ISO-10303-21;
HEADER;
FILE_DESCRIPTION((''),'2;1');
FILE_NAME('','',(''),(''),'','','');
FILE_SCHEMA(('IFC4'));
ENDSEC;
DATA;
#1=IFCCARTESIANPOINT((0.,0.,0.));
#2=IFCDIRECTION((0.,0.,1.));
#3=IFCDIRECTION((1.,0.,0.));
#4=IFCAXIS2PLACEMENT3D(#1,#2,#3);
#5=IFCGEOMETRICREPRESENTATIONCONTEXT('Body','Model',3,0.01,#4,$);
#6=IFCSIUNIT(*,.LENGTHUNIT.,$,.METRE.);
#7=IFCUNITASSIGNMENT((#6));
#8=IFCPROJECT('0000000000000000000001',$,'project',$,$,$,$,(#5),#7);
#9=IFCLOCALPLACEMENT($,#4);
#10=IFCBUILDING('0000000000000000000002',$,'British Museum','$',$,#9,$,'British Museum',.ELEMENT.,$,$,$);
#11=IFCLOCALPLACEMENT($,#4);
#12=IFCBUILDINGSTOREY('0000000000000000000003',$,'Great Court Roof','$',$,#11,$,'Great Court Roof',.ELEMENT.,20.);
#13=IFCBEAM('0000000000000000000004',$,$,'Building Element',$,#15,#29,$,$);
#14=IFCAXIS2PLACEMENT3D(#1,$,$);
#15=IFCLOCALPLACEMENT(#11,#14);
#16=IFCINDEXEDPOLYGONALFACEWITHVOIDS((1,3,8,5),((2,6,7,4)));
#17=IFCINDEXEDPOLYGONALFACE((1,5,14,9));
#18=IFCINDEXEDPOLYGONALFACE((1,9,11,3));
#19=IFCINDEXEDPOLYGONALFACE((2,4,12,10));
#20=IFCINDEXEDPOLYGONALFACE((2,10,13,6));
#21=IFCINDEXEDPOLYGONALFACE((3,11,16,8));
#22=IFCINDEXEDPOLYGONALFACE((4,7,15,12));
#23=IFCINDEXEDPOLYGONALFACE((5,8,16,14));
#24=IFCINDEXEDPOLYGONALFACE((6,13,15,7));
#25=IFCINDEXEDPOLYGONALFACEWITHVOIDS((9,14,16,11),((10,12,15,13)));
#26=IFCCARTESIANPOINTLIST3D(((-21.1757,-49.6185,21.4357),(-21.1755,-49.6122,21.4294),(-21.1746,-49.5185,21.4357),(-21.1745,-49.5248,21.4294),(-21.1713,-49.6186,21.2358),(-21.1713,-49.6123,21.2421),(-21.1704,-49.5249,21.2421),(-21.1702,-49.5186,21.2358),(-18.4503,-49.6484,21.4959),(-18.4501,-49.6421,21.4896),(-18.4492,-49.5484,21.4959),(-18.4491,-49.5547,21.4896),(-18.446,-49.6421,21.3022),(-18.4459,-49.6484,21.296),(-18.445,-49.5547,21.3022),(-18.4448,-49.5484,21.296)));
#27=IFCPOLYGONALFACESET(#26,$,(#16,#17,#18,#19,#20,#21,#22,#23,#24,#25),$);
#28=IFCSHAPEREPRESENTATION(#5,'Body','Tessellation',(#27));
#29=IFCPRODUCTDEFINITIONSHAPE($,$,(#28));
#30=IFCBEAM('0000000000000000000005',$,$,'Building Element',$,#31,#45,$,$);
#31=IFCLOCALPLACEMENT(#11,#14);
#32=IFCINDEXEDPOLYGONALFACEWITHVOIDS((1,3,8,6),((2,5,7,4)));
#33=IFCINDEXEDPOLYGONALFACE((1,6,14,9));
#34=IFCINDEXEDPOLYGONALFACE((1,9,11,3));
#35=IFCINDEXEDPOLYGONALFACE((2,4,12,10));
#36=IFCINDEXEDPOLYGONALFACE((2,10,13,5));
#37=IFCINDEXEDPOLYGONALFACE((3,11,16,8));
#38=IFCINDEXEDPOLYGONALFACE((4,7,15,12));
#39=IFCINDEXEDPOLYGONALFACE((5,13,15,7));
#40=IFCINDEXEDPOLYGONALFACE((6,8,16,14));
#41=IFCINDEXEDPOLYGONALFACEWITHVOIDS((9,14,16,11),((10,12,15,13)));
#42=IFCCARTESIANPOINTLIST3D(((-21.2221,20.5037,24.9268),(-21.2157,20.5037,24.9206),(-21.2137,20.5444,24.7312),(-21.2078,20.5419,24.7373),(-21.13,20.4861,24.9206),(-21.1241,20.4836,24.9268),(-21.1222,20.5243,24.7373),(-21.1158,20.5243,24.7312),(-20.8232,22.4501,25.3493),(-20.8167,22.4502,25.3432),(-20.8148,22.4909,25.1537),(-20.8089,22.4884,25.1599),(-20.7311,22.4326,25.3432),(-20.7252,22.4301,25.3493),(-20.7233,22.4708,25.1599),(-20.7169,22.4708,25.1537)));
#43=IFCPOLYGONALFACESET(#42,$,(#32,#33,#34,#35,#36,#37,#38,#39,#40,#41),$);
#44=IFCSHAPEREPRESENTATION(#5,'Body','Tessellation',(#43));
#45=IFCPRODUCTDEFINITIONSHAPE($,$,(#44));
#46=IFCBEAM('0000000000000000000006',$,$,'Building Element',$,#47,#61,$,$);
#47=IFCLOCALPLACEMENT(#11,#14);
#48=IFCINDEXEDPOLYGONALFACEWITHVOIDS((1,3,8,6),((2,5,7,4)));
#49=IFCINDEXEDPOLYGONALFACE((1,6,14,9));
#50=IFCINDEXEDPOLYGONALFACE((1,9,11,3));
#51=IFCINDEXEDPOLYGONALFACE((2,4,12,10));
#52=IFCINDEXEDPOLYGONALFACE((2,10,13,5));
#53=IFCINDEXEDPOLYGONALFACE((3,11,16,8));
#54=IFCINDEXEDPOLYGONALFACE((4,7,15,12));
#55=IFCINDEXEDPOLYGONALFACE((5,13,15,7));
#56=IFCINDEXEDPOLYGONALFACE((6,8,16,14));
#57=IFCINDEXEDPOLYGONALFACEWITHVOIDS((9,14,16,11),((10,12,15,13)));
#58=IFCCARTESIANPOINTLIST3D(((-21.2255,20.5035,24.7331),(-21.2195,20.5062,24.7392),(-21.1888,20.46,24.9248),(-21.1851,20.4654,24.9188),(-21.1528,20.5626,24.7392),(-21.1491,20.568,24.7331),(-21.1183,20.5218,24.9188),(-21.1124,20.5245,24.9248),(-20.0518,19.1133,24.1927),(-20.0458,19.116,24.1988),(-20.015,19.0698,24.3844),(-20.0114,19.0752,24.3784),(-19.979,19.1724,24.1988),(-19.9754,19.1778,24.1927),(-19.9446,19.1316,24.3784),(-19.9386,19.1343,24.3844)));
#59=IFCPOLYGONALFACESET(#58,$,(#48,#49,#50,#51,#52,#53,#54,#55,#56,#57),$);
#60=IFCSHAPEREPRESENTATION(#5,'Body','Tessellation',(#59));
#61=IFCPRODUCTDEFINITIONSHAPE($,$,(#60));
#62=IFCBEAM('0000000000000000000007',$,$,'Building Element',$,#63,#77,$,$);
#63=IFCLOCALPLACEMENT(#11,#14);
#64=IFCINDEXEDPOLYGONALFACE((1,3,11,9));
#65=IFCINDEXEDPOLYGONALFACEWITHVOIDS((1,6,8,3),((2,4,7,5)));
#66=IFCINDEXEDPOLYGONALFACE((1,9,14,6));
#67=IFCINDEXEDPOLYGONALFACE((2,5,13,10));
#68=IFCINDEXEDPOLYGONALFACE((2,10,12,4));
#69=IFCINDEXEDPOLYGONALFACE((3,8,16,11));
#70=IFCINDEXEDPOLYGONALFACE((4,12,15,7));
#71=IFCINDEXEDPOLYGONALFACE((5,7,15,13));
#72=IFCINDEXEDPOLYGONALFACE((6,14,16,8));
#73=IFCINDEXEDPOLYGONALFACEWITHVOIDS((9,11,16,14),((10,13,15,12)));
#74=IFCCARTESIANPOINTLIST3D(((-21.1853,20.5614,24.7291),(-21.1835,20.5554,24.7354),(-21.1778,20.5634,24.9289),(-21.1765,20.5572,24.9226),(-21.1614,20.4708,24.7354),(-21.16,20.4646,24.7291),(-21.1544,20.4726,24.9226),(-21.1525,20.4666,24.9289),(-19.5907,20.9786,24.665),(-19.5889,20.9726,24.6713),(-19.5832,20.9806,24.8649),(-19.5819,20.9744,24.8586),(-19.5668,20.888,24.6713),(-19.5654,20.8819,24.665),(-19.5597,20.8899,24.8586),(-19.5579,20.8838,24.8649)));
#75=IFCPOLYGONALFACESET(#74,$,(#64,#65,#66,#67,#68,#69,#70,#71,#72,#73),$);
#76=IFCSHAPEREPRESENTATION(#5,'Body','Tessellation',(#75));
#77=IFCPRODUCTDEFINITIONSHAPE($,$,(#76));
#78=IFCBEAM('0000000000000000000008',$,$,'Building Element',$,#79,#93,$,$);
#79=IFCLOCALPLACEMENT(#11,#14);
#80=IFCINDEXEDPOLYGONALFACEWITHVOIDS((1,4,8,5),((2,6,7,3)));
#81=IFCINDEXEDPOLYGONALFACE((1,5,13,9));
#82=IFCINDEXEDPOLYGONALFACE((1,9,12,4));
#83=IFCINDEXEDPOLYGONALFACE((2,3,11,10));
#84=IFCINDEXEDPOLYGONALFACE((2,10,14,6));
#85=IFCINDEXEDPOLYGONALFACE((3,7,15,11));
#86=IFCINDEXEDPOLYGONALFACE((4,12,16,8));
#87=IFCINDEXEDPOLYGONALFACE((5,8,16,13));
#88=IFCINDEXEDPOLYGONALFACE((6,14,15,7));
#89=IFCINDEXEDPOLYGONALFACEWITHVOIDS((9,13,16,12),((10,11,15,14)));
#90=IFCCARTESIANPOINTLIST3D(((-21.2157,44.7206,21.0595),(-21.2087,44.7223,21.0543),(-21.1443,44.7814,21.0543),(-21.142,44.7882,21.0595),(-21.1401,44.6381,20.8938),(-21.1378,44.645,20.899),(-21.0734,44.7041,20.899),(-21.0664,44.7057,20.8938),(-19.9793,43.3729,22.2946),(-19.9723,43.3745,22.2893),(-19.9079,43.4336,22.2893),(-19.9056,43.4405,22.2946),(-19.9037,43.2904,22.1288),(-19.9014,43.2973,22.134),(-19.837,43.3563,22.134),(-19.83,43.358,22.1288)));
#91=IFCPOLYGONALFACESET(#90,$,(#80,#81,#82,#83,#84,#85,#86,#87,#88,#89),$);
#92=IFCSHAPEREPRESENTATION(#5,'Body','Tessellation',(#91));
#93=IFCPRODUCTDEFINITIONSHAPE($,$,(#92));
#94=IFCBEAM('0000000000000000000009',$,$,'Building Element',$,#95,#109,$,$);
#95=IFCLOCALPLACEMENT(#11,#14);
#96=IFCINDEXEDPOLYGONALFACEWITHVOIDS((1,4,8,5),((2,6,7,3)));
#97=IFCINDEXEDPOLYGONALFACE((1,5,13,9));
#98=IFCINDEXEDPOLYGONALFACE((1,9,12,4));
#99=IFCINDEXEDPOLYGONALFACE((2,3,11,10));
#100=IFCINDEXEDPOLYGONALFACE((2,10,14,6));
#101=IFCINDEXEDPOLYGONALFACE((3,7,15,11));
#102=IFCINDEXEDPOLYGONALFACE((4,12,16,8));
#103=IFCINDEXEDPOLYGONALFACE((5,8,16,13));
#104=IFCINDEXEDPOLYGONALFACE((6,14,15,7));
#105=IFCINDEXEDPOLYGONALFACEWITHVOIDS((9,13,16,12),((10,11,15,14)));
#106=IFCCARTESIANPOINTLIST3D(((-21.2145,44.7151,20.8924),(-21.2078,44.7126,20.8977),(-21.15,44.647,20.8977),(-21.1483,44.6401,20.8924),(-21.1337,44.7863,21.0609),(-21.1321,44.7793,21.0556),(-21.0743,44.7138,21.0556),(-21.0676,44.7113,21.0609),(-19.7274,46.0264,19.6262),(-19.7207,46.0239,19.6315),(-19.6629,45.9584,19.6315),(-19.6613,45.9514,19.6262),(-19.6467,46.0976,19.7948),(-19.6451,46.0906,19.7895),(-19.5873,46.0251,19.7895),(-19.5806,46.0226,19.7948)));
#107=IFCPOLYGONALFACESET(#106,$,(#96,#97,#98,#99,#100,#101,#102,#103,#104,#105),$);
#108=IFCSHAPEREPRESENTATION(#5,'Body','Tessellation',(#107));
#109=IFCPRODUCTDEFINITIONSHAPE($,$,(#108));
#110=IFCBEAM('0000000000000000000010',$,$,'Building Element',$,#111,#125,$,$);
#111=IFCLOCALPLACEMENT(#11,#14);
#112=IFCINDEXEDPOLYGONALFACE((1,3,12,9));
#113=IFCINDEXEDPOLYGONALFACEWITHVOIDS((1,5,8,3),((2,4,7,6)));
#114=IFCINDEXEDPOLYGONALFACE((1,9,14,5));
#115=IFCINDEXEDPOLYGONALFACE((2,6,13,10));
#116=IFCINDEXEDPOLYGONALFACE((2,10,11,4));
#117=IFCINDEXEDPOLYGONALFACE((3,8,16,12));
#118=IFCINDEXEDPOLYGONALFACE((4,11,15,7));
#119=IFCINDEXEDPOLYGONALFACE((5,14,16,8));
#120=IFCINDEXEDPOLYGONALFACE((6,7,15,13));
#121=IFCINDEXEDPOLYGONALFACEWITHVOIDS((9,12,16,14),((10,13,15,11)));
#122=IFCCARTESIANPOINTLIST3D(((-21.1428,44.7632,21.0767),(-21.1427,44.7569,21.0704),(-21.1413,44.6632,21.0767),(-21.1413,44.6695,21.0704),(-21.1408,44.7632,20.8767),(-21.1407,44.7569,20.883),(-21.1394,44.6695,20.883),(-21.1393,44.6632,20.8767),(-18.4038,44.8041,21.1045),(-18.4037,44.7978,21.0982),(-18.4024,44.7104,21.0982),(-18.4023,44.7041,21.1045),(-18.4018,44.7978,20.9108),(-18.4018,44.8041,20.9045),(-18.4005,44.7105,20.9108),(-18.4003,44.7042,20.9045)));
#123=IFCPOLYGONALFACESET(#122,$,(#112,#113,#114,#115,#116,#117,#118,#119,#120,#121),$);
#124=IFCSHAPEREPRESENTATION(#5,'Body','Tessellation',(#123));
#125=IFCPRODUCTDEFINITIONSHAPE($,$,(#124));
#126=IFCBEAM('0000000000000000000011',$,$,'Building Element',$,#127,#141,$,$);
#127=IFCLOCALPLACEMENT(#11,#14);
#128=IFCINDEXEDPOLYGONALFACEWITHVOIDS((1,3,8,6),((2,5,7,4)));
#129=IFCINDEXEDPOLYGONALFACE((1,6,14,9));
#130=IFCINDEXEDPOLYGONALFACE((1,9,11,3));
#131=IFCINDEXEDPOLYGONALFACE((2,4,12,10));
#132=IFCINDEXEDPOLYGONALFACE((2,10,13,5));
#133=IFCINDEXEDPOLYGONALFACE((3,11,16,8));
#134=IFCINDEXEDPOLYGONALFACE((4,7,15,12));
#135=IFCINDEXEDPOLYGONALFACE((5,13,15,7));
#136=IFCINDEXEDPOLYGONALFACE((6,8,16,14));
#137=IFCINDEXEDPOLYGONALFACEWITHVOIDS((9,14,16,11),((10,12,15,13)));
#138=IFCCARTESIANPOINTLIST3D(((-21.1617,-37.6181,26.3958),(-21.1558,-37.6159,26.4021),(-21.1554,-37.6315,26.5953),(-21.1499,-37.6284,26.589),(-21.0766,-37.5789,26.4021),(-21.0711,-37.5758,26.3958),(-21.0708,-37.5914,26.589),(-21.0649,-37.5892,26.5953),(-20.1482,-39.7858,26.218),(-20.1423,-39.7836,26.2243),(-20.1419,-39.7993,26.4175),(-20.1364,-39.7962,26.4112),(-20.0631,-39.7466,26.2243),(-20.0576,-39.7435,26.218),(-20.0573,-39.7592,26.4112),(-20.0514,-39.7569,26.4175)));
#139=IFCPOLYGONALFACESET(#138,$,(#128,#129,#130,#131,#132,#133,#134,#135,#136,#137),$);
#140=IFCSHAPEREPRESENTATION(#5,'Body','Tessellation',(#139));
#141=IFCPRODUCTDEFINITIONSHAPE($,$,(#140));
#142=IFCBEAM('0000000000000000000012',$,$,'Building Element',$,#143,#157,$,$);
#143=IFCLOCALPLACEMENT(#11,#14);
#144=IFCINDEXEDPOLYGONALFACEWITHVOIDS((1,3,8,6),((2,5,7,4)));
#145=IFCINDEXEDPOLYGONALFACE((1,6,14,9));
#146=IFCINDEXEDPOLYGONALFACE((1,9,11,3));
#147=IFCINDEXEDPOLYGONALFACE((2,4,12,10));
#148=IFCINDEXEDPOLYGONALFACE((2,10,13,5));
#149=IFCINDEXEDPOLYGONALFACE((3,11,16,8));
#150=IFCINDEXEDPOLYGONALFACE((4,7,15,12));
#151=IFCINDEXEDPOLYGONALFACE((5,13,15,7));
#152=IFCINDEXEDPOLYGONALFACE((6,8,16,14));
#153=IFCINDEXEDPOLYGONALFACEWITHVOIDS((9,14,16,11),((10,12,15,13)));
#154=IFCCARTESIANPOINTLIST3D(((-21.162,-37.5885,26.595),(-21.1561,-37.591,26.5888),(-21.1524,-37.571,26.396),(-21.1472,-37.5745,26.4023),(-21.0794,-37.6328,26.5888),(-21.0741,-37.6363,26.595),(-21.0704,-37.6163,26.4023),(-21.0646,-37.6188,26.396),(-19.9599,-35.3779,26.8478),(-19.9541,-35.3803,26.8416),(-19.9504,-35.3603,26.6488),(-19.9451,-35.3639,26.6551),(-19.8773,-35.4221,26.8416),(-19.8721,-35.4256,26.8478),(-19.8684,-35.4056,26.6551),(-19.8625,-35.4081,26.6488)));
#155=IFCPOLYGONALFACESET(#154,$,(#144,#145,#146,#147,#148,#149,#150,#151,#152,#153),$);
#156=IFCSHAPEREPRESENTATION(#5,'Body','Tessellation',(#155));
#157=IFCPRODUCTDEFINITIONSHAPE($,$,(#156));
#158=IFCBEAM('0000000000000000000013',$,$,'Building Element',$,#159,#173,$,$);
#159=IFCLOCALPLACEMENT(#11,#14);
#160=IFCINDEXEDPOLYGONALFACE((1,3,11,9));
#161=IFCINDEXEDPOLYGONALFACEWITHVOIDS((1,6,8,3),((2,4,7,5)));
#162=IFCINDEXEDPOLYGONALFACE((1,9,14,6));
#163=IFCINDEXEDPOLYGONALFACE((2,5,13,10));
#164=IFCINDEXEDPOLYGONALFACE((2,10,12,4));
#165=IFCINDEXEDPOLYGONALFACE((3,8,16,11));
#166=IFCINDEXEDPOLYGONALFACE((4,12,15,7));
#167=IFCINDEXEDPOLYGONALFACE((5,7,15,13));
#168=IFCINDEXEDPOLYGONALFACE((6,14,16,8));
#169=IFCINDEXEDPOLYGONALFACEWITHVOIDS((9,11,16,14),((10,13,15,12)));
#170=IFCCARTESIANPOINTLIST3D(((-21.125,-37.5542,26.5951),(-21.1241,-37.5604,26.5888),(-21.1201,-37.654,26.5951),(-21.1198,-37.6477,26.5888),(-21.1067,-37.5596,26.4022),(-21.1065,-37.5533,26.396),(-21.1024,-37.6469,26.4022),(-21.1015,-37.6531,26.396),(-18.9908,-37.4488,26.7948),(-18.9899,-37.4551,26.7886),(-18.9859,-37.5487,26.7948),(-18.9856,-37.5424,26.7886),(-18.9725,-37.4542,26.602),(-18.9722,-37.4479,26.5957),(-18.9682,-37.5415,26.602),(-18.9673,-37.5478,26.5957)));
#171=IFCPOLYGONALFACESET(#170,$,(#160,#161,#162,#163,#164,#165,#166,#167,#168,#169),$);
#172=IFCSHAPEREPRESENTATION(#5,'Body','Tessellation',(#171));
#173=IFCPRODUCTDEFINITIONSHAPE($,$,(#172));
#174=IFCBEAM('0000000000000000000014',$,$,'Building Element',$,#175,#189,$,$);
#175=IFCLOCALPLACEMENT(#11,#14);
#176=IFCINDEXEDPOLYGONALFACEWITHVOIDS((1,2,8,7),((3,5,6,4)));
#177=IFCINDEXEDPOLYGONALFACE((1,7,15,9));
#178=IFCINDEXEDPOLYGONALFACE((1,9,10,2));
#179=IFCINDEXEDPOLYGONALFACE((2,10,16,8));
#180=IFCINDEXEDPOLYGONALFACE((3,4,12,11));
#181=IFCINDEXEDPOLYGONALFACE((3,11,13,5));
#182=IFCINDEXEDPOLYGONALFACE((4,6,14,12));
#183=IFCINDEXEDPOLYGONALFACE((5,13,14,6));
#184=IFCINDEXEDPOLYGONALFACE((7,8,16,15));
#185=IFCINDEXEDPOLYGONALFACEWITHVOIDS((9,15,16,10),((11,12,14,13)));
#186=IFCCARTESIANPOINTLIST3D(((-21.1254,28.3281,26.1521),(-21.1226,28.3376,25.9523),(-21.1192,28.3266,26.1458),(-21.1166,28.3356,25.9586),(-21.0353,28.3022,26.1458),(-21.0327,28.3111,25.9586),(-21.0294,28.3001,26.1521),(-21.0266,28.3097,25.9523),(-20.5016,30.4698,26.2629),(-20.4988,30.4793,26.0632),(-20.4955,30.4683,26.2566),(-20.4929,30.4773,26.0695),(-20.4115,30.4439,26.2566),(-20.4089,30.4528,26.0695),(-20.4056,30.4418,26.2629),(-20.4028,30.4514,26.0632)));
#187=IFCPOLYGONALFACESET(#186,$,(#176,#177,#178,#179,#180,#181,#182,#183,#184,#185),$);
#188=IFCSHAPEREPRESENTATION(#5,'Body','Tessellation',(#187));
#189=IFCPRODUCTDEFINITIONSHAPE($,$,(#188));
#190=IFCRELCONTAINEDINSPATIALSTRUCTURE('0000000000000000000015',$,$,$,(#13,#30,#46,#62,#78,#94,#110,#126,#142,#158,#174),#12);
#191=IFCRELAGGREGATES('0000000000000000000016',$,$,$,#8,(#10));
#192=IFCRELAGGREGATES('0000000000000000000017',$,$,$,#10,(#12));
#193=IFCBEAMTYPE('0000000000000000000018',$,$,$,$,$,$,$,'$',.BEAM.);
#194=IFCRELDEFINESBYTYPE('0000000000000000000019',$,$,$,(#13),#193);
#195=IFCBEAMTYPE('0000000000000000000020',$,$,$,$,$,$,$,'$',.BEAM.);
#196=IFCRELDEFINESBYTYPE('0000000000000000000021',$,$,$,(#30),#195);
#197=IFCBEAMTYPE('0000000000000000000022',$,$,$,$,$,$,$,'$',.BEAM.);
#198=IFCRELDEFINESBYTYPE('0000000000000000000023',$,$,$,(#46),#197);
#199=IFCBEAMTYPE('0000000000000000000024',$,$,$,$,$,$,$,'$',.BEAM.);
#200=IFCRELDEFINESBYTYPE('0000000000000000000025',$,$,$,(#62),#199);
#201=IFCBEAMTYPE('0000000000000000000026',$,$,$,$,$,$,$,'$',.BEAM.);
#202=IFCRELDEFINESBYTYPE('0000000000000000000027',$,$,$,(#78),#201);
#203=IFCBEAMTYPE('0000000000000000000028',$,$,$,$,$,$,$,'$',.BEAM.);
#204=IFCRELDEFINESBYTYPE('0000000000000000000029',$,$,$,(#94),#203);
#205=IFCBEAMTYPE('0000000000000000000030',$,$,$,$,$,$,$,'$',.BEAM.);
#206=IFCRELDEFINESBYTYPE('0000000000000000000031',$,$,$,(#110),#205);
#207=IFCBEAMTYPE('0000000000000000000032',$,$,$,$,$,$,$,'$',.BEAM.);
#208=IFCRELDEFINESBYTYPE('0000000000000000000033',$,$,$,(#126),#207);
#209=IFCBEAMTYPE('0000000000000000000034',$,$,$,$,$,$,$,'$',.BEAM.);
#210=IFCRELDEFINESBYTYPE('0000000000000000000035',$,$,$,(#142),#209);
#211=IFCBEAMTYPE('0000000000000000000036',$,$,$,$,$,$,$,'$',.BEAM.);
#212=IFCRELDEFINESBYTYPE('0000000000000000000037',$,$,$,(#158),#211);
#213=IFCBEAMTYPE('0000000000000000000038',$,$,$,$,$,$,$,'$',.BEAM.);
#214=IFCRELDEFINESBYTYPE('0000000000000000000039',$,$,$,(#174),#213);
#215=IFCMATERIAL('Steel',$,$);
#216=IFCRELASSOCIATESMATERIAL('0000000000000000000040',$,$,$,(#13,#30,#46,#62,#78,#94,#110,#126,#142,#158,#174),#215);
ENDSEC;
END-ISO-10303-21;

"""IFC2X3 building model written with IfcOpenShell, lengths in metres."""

from ifc_helpers import new_model, si_unit, frame, origin_with_axes, origin_2d, place, context, project, spatial, hollow_rectangle, extrude, material, type_object, element, save


model = new_model("IFC2X3")

# Units and contexts
model_context = context("Model", 3, precision=0.01, world=origin_with_axes(), identifier="Body")
ifc_project = project(units=[si_unit("LENGTHUNIT", "METRE")], contexts=[model_context])

# Building, storey
building_placement = place(None, origin_with_axes())
building = spatial("IfcBuilding", under=ifc_project, at=building_placement, Name="British Museum", Description="$", LongName="British Museum", CompositionType="ELEMENT")
storey_placement = place(None, origin_with_axes())
storey = spatial("IfcBuildingStorey", under=building, at=storey_placement, Name="Great Court Roof", Description="$", LongName="Great Court Roof", CompositionType="ELEMENT", Elevation=20.0)

# Beams
ifc_material = material(Name="Steel")
beam_type_1 = type_object("IfcBeamType", ElementType="$", PredefinedType="BEAM")
beam_1_placement = place(None, origin_with_axes())
element("IfcBeam", 1, at=beam_1_placement, inside=storey, type_object=beam_type_1, material=ifc_material, Description="Building Element", context=model_context, shape_type="SweptSolid", body=[
    extrude(hollow_rectangle(XDim=0.1, YDim=0.2, WallThickness=0.0063, InnerFilletRadius=0.0, OuterFilletRadius=0.0, at=origin_2d()), frame((-21.1729, -49.5685, 21.3358), z_axis=(0.999697, -0.010944, 0.022069), x_axis=(0.010946, 0.99994, 0.0)), (0.0, 0.0, 1.0), 2.7262),
])
beam_type_2 = type_object("IfcBeamType", ElementType="$", PredefinedType="BEAM")
beam_2_placement = place(None, origin_with_axes())
element("IfcBeam", 2, at=beam_2_placement, inside=storey, type_object=beam_type_2, material=ifc_material, Description="Building Element", context=model_context, shape_type="SweptSolid", body=[
    extrude(hollow_rectangle(XDim=0.1, YDim=0.2, WallThickness=0.0063, InnerFilletRadius=0.0, OuterFilletRadius=0.0, at=origin_2d()), frame((-21.1689, 20.514, 24.829), z_axis=(0.196376, 0.958212, 0.208004), x_axis=(-0.979639, 0.200767, 0.0)), (0.0, 0.0, 1.0), 2.0314),
])
beam_type_3 = type_object("IfcBeamType", ElementType="$", PredefinedType="BEAM")
beam_3_placement = place(None, origin_with_axes())
element("IfcBeam", 3, at=beam_3_placement, inside=storey, type_object=beam_type_3, material=ifc_material, Description="Building Element", context=model_context, shape_type="SweptSolid", body=[
    extrude(hollow_rectangle(XDim=0.1, YDim=0.2, WallThickness=0.0063, InnerFilletRadius=0.0, OuterFilletRadius=0.0, at=origin_2d()), frame((-21.1689, 20.514, 24.829), z_axis=(0.618409, -0.732461, -0.28473), x_axis=(0.764088, 0.645112, 0.0)), (0.0, 0.0, 1.0), 1.898),
])
beam_type_4 = type_object("IfcBeamType", ElementType="$", PredefinedType="BEAM")
beam_4_placement = place(None, origin_with_axes())
element("IfcBeam", 4, at=beam_4_placement, inside=storey, type_object=beam_type_4, material=ifc_material, Description="Building Element", context=model_context, shape_type="SweptSolid", body=[
    extrude(hollow_rectangle(XDim=0.1, YDim=0.2, WallThickness=0.0063, InnerFilletRadius=0.0, OuterFilletRadius=0.0, at=origin_2d()), frame((-21.1689, 20.514, 24.829), z_axis=(0.966707, 0.252926, -0.038815), x_axis=(-0.253117, 0.967436, 0.0)), (0.0, 0.0, 1.0), 1.6495),
])
beam_type_5 = type_object("IfcBeamType", ElementType="$", PredefinedType="BEAM")
beam_5_placement = place(None, origin_with_axes())
element("IfcBeam", 5, at=beam_5_placement, inside=storey, type_object=beam_type_5, material=ifc_material, Description="Building Element", context=model_context, shape_type="SweptSolid", body=[
    extrude(hollow_rectangle(XDim=0.1, YDim=0.2, WallThickness=0.0063, InnerFilletRadius=0.0, OuterFilletRadius=0.0, at=origin_2d()), frame((-21.141, 44.7132, 20.9767), z_axis=(0.560245, -0.610694, 0.559623), x_axis=(0.736888, 0.676015, 0.0)), (0.0, 0.0, 1.0), 2.2069),
])
beam_type_6 = type_object("IfcBeamType", ElementType="$", PredefinedType="BEAM")
beam_6_placement = place(None, origin_with_axes())
element("IfcBeam", 6, at=beam_6_placement, inside=storey, type_object=beam_type_6, material=ifc_material, Description="Building Element", context=model_context, shape_type="SweptSolid", body=[
    extrude(hollow_rectangle(XDim=0.1, YDim=0.2, WallThickness=0.0063, InnerFilletRadius=0.0, OuterFilletRadius=0.0, at=origin_2d()), frame((-21.141, 44.7132, 20.9767), z_axis=(0.632129, 0.557428, -0.538226), x_axis=(-0.6614, 0.750033, 0.0)), (0.0, 0.0, 1.0), 2.3524),
])
beam_type_7 = type_object("IfcBeamType", ElementType="$", PredefinedType="BEAM")
beam_7_placement = place(None, origin_with_axes())
element("IfcBeam", 7, at=beam_7_placement, inside=storey, type_object=beam_type_7, material=ifc_material, Description="Building Element", context=model_context, shape_type="SweptSolid", body=[
    extrude(hollow_rectangle(XDim=0.1, YDim=0.2, WallThickness=0.0063, InnerFilletRadius=0.0, OuterFilletRadius=0.0, at=origin_2d()), frame((-21.141, 44.7132, 20.9767), z_axis=(0.999837, 0.01495, 0.010172), x_axis=(-0.014951, 0.999888, 0.0)), (0.0, 0.0, 1.0), 2.7394),
])
beam_type_8 = type_object("IfcBeamType", ElementType="$", PredefinedType="BEAM")
beam_8_placement = place(None, origin_with_axes())
element("IfcBeam", 8, at=beam_8_placement, inside=storey, type_object=beam_type_8, material=ifc_material, Description="Building Element", context=model_context, shape_type="SweptSolid", body=[
    extrude(hollow_rectangle(XDim=0.1, YDim=0.2, WallThickness=0.0063, InnerFilletRadius=0.0, OuterFilletRadius=0.0, at=origin_2d()), frame((-21.1133, -37.6036, 26.4955), z_axis=(0.422372, -0.903389, -0.074102), x_axis=(0.905879, 0.423536, 0.0)), (0.0, 0.0, 1.0), 2.3995),
])
beam_type_9 = type_object("IfcBeamType", ElementType="$", PredefinedType="BEAM")
beam_9_placement = place(None, origin_with_axes())
element("IfcBeam", 9, at=beam_9_placement, inside=storey, type_object=beam_type_9, material=ifc_material, Description="Building Element", context=model_context, shape_type="SweptSolid", body=[
    extrude(hollow_rectangle(XDim=0.1, YDim=0.2, WallThickness=0.0063, InnerFilletRadius=0.0, OuterFilletRadius=0.0, at=origin_2d()), frame((-21.1133, -37.6036, 26.4955), z_axis=(0.475309, 0.874122, 0.099957), x_axis=(-0.878522, 0.477702, 0.0)), (0.0, 0.0, 1.0), 2.529),
])
beam_type_10 = type_object("IfcBeamType", ElementType="$", PredefinedType="BEAM")
beam_10_placement = place(None, origin_with_axes())
element("IfcBeam", 10, at=beam_10_placement, inside=storey, type_object=beam_type_10, material=ifc_material, Description="Building Element", context=model_context, shape_type="SweptSolid", body=[
    extrude(hollow_rectangle(XDim=0.1, YDim=0.2, WallThickness=0.0063, InnerFilletRadius=0.0, OuterFilletRadius=0.0, at=origin_2d()), frame((-21.1133, -37.6036, 26.4955), z_axis=(0.99445, 0.049086, 0.093058), x_axis=(-0.0493, 0.998784, 0.0)), (0.0, 0.0, 1.0), 2.1462),
])
beam_type_11 = type_object("IfcBeamType", ElementType="$", PredefinedType="BEAM")
beam_11_placement = place(None, origin_with_axes())
element("IfcBeam", 11, at=beam_11_placement, inside=storey, type_object=beam_type_11, material=ifc_material, Description="Building Element", context=model_context, shape_type="SweptSolid", body=[
    extrude(hollow_rectangle(XDim=0.1, YDim=0.2, WallThickness=0.0063, InnerFilletRadius=0.0, OuterFilletRadius=0.0, at=origin_2d()), frame((-21.076, 28.3189, 26.0522), z_axis=(0.279292, 0.958922, 0.049637), x_axis=(-0.960106, 0.279636, 0.0)), (0.0, 0.0, 1.0), 2.2335),
])

save(model, "model.ifc")
